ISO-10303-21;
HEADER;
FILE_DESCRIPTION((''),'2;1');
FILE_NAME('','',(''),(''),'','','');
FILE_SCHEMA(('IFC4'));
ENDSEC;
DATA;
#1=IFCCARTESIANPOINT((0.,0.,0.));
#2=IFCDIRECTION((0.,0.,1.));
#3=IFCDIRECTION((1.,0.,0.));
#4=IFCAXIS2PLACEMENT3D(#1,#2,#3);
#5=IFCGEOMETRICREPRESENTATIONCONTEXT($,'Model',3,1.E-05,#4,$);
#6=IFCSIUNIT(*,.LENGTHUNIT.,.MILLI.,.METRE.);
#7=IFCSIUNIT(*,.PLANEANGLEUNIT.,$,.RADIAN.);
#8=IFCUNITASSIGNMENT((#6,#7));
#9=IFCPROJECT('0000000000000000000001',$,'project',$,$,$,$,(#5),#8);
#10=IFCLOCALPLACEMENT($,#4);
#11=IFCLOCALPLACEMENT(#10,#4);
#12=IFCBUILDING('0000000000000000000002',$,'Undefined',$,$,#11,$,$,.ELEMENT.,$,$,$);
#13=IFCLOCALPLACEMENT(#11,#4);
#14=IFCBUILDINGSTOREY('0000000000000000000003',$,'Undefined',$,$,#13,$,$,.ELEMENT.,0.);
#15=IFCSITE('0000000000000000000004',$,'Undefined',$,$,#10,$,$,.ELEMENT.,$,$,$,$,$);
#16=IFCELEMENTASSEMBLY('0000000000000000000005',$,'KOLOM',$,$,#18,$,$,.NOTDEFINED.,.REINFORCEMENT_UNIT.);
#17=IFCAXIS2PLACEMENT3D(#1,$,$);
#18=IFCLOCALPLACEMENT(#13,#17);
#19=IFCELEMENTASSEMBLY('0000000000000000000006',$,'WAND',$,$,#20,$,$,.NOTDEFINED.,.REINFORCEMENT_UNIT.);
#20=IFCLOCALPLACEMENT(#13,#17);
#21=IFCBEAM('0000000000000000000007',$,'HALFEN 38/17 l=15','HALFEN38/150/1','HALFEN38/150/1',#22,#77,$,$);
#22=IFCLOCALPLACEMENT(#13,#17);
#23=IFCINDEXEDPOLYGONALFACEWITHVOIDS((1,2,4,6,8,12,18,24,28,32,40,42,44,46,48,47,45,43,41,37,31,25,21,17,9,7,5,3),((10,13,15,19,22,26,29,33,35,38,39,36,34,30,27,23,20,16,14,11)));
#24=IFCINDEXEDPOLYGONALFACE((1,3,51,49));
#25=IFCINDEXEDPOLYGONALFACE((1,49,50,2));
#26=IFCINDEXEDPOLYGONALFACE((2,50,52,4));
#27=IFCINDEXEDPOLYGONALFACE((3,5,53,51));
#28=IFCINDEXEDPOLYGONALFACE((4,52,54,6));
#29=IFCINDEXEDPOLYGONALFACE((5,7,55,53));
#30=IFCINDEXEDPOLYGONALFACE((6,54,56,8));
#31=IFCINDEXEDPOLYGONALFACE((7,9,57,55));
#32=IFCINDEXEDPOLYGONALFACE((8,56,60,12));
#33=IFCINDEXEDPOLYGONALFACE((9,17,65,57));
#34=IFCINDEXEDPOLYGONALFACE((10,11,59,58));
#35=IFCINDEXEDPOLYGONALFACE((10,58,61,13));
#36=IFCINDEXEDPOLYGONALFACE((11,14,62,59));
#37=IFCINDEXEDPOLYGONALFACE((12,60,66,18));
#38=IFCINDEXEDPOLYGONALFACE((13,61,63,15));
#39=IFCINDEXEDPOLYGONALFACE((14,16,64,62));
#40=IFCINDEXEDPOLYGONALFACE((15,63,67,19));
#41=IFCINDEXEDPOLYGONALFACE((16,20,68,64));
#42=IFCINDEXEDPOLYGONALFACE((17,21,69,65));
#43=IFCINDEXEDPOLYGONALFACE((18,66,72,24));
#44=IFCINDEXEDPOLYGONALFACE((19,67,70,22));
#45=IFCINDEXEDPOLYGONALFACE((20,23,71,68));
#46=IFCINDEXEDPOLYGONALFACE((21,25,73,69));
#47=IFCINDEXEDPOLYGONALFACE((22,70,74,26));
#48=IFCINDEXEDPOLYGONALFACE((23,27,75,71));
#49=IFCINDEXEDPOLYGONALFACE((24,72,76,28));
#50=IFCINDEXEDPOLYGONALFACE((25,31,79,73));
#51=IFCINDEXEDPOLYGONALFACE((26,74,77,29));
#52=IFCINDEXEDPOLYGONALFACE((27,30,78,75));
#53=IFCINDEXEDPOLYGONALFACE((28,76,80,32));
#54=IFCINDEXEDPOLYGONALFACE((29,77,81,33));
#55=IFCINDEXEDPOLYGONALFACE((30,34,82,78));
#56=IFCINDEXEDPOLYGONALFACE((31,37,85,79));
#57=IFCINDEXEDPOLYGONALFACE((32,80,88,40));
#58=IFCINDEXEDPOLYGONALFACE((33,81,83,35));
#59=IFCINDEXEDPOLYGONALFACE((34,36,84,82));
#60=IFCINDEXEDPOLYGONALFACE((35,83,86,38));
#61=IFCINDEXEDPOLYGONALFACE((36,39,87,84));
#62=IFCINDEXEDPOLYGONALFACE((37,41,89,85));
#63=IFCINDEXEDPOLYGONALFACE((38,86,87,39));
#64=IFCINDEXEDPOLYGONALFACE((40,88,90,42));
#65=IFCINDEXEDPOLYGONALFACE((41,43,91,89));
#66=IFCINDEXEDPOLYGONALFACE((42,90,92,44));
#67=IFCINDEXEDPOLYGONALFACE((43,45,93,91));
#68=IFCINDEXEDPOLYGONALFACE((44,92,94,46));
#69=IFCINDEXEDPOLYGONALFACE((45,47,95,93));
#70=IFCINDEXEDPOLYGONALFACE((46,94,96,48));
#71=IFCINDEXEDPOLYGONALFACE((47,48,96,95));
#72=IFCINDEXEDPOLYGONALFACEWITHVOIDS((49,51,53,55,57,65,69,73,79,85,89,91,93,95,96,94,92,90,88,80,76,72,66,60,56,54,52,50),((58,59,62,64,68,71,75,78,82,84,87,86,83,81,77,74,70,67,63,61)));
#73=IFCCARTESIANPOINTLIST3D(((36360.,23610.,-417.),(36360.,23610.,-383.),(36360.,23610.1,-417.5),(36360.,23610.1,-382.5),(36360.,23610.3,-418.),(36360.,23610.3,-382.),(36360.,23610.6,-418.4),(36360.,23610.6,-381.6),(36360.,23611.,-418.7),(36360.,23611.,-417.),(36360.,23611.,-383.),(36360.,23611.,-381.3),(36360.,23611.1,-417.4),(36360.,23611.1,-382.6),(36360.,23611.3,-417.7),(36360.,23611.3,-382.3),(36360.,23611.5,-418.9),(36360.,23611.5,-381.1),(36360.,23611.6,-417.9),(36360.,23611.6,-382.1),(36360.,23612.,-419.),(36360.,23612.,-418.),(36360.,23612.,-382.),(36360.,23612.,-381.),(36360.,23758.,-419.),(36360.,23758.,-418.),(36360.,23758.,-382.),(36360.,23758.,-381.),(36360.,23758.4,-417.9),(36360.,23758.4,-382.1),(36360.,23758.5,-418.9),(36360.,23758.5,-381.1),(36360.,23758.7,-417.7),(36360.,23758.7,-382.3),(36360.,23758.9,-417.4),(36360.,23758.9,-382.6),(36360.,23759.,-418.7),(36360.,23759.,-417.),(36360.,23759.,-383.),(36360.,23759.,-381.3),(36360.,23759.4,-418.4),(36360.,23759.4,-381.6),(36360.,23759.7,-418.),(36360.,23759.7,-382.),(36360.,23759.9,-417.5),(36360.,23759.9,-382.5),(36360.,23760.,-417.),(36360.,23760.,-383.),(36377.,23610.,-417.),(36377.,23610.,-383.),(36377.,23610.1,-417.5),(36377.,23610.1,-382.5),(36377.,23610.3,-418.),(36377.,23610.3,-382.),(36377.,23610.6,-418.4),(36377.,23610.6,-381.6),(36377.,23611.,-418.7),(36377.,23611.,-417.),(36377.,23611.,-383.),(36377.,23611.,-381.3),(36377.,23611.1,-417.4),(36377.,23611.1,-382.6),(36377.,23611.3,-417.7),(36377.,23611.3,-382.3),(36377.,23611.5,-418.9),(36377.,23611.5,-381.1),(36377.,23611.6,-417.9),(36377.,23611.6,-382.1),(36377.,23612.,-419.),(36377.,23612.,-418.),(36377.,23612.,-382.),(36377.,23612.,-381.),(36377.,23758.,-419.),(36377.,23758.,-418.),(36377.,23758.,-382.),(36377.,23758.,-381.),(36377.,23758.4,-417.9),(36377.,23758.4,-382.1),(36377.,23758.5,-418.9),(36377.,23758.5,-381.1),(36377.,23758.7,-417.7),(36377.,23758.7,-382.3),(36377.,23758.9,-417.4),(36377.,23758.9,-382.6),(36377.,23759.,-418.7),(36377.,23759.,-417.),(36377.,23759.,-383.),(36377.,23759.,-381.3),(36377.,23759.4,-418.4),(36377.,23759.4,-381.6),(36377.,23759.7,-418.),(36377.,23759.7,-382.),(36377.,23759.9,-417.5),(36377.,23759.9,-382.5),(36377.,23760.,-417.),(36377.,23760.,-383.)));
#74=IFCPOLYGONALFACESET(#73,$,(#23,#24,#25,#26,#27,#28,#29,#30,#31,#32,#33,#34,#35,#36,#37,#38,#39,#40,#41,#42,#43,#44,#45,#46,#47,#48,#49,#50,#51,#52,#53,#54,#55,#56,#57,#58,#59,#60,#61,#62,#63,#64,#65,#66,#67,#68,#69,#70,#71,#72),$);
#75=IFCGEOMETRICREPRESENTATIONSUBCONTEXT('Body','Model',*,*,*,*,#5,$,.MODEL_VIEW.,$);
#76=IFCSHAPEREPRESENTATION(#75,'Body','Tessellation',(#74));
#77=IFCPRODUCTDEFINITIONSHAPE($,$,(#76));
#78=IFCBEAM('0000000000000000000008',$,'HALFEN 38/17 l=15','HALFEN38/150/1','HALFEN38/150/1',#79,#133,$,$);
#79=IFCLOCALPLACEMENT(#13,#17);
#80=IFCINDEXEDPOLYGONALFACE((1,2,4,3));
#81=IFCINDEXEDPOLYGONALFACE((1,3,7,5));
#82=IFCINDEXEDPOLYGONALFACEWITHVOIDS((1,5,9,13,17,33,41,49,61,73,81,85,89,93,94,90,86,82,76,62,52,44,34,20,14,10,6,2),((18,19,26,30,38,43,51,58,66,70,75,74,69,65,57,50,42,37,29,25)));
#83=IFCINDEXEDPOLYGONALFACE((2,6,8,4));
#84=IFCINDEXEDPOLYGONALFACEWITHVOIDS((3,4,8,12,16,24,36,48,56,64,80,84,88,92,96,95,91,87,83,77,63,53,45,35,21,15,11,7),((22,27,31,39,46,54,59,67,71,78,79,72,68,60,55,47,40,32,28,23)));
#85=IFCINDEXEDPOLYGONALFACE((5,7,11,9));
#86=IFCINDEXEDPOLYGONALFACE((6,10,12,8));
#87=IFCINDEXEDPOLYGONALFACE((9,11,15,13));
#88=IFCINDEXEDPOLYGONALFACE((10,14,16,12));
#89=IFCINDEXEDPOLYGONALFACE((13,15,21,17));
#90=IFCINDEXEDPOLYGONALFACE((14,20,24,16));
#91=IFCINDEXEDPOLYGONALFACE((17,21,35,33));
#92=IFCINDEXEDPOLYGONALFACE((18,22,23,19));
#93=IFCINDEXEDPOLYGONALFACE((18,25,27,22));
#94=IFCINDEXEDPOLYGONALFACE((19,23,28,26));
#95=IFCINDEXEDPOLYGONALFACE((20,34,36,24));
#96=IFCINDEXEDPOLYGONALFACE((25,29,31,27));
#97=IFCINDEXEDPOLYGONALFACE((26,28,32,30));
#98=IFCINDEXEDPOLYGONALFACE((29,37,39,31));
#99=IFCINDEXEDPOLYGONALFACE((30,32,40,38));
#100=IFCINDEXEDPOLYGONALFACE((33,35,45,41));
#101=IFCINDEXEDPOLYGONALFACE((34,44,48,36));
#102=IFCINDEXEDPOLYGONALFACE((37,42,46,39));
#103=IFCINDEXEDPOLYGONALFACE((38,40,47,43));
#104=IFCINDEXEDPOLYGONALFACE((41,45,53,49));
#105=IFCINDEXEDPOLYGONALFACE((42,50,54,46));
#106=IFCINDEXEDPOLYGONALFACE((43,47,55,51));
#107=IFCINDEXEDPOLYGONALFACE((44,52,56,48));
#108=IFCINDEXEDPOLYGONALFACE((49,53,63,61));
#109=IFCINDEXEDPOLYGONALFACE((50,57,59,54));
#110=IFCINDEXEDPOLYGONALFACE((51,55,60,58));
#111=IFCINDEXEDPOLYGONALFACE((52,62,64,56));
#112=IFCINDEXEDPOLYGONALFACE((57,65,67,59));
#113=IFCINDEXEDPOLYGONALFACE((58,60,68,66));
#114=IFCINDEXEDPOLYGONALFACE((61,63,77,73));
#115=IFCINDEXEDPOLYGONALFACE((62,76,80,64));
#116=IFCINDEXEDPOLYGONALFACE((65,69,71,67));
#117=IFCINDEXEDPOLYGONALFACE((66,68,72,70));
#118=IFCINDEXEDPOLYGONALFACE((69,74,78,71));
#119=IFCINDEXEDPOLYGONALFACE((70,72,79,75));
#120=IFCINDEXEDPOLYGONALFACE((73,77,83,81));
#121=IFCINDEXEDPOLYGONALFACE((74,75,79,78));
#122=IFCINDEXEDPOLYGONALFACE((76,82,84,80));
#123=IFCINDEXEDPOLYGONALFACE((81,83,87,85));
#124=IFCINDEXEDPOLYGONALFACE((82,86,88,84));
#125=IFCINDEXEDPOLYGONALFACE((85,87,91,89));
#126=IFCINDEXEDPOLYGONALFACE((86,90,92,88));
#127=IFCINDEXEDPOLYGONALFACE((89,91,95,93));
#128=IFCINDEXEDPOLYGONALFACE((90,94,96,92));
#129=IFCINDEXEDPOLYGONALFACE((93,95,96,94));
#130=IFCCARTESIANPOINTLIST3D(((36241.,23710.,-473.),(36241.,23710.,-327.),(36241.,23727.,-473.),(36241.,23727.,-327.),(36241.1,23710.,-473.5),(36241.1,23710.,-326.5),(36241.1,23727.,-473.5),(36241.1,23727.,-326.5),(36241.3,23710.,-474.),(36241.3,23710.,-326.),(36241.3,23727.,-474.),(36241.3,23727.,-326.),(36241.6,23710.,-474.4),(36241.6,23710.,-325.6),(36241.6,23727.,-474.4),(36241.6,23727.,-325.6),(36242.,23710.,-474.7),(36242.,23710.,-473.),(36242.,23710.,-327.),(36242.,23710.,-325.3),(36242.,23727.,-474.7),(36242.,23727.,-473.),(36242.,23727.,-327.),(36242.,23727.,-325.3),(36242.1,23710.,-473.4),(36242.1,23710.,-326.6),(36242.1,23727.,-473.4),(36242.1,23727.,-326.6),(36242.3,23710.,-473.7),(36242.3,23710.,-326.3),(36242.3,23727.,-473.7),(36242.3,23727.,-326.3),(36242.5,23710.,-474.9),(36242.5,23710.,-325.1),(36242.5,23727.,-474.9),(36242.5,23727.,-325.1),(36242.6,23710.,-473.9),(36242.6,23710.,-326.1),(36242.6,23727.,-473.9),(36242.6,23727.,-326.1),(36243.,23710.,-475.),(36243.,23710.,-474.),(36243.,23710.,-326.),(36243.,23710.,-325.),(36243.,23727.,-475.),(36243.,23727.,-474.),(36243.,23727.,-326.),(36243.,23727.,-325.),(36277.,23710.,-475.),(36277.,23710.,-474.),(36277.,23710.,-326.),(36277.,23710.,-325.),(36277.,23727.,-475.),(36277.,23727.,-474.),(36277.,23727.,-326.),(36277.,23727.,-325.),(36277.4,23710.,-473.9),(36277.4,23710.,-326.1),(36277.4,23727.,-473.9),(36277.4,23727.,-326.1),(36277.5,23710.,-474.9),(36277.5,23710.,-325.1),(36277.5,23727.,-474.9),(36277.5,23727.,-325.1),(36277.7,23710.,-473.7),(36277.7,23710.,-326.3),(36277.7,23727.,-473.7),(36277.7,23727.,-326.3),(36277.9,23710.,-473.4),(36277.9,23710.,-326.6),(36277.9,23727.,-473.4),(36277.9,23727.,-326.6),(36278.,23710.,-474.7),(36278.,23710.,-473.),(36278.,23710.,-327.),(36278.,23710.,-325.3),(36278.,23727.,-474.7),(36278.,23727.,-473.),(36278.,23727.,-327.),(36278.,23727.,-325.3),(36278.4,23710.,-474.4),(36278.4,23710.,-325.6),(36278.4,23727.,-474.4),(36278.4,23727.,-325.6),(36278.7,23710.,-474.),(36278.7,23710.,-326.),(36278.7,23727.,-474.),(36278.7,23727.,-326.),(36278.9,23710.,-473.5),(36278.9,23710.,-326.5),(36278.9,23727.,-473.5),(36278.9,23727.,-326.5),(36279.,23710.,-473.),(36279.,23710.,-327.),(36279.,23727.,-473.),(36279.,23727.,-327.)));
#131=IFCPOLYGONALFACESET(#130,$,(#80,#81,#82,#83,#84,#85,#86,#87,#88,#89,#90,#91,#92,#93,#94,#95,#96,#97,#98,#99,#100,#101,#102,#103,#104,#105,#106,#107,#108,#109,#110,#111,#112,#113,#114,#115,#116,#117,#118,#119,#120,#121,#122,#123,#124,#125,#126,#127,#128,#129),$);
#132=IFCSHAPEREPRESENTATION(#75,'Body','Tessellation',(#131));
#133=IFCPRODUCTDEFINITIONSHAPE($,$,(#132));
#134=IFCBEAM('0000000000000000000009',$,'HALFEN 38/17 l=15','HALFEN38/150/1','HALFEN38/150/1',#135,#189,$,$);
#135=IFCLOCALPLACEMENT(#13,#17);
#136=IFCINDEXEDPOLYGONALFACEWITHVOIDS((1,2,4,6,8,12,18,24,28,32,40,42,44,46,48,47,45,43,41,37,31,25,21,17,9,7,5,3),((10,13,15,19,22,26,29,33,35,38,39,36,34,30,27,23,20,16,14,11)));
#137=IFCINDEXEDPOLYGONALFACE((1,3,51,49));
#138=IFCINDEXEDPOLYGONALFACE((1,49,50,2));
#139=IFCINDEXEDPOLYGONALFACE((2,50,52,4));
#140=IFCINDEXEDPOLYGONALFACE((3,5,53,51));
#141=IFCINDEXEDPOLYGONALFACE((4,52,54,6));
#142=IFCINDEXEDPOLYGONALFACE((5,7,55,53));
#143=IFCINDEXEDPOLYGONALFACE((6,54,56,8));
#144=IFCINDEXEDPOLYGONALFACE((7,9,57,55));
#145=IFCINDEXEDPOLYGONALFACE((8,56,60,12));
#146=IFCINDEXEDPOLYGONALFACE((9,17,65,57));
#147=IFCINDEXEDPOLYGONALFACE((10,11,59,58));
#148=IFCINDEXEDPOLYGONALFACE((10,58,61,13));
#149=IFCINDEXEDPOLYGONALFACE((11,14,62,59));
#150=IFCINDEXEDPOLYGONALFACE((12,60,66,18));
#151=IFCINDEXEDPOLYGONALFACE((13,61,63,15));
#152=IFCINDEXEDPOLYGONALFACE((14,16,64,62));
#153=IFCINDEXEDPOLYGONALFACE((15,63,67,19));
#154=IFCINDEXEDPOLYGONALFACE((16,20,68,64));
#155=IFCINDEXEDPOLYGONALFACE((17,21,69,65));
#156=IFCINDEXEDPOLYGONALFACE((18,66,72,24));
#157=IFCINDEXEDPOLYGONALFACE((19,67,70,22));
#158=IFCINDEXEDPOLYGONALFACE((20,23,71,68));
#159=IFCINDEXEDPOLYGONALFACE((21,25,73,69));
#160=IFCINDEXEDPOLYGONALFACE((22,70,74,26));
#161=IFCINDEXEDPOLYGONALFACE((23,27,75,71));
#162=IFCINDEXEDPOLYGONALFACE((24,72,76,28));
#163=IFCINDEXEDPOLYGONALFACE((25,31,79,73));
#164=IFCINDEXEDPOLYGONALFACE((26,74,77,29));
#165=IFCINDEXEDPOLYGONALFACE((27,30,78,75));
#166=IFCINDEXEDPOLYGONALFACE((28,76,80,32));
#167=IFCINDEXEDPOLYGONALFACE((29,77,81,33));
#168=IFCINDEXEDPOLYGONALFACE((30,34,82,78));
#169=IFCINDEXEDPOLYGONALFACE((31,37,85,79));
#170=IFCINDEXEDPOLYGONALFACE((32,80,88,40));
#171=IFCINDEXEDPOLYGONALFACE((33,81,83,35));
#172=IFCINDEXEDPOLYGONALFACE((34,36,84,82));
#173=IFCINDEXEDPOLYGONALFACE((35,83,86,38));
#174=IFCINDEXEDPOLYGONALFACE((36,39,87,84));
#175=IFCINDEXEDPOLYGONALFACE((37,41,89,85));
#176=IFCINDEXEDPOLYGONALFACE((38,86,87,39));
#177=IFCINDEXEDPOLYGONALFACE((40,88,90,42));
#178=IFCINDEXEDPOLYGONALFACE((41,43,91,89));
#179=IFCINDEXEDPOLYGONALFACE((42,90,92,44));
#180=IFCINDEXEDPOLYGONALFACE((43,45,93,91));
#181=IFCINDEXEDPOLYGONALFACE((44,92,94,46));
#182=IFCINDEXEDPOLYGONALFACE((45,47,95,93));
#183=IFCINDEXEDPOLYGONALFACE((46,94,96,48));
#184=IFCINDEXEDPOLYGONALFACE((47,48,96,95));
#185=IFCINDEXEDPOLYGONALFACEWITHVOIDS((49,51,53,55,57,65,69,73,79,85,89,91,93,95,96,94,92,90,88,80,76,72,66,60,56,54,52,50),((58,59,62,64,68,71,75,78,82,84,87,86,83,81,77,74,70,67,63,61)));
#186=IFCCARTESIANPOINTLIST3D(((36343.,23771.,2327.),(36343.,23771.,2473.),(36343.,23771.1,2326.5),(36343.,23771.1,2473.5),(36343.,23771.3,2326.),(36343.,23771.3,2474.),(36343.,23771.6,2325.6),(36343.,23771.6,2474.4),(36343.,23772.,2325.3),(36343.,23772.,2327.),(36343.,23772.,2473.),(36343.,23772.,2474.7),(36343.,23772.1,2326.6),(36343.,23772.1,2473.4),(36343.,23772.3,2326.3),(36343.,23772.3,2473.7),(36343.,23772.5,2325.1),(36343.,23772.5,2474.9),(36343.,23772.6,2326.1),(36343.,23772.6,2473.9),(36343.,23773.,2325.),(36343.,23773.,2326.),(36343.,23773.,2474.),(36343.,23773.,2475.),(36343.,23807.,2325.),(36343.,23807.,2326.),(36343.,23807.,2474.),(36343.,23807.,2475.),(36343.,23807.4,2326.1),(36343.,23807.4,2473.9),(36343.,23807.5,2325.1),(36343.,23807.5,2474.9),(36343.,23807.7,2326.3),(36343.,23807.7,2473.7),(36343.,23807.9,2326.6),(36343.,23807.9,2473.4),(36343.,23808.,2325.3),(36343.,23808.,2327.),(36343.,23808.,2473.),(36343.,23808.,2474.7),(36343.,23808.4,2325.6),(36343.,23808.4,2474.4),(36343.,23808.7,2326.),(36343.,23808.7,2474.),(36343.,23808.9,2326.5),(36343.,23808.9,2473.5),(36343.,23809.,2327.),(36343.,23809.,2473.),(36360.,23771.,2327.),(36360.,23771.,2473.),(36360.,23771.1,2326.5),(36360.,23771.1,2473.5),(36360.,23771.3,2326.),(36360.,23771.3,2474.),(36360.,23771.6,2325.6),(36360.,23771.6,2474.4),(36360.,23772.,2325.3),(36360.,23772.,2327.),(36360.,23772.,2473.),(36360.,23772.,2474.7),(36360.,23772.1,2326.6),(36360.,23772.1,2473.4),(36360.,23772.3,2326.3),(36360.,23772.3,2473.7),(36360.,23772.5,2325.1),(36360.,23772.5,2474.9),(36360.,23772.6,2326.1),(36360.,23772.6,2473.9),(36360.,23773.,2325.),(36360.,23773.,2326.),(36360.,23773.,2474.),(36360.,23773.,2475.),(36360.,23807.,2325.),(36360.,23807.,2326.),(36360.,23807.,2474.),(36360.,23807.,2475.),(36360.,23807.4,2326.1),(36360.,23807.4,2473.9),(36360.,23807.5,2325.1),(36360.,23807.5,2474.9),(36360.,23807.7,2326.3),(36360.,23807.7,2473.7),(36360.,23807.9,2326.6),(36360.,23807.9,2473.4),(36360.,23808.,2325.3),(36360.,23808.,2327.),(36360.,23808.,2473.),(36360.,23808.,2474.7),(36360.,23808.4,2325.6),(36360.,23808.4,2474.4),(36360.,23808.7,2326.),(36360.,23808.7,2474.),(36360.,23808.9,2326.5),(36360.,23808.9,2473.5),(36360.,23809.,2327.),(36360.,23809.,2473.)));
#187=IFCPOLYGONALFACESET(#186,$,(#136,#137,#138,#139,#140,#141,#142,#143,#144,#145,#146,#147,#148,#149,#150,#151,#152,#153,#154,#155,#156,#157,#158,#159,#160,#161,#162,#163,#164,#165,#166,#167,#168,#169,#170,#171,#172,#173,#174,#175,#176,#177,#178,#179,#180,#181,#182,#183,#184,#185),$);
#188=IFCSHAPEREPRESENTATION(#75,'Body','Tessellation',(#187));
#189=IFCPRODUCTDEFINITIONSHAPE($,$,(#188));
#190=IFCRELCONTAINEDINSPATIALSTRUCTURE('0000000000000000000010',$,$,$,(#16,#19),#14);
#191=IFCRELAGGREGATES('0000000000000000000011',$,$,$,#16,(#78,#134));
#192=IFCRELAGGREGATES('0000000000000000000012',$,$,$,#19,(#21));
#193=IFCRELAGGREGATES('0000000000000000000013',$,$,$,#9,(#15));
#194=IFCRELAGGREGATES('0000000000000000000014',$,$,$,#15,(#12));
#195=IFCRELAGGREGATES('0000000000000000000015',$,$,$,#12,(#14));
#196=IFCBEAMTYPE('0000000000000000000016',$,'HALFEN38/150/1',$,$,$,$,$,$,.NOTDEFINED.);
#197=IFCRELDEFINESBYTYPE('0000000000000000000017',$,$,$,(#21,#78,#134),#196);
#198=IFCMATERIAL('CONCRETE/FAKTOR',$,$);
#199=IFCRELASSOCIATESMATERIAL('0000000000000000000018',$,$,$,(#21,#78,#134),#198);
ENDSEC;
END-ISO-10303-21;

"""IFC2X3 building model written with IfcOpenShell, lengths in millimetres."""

from ifc_helpers import new_model, si_unit, frame, frame_2d, origin_with_axes, place, context, subcontext, project, spatial, hollow_rectangle, extrude, material, type_object, element, aggregate, save


model = new_model("IFC2X3")

# Units and contexts
model_context = context("Model", 3, precision=1e-05, world=origin_with_axes())
body_context = subcontext(model_context, "Body", "Model", "MODEL_VIEW")
ifc_project = project(units=[si_unit("LENGTHUNIT", "METRE", prefix="MILLI"), si_unit("PLANEANGLEUNIT", "RADIAN")], contexts=[model_context])

# Site, building, storey
site_placement = place(None, origin_with_axes())
site = spatial("IfcSite", under=ifc_project, at=site_placement, Name="Undefined", CompositionType="ELEMENT")
building_placement = place(site_placement, origin_with_axes())
building = spatial("IfcBuilding", under=site, at=building_placement, Name="Undefined", CompositionType="ELEMENT")
storey_placement = place(building_placement, origin_with_axes())
storey = spatial("IfcBuildingStorey", under=building, at=storey_placement, Name="Undefined", CompositionType="ELEMENT", Elevation=0.0)

# Element assemblies, beam
ifc_material_1 = material(Name="CONCRETE/FAKTOR")
assembly_1_placement = place(storey_placement, origin_with_axes())
assembly_1 = element("IfcElementAssembly", 1, at=assembly_1_placement, inside=storey, Name="KOLOM", AssemblyPlace="NOTDEFINED", PredefinedType="REINFORCEMENT_UNIT")
beam_type_1 = type_object("IfcBeamType", Name="HALFEN38/150/1", PredefinedType="NOTDEFINED")
assembly_2_placement = place(storey_placement, origin_with_axes())
assembly_2 = element("IfcElementAssembly", 2, at=assembly_2_placement, inside=storey, Name="WAND", AssemblyPlace="NOTDEFINED", PredefinedType="REINFORCEMENT_UNIT")
beam_1_placement = place(assembly_2_placement, frame((36360.0, 23685.0, -400.0), z_axis=(0.0, 0.0, 1.0), x_axis=(1.0, 0.0, 0.0)))
beam_1 = element("IfcBeam", 3, at=beam_1_placement, type_object=beam_type_1, material=ifc_material_1, Name="HALFEN 38/17 l=15", Description="HALFEN38/150/1", ObjectType="HALFEN38/150/1", context=body_context, shape_type="SweptSolid", body=[
    extrude(hollow_rectangle(XDim=150.0, YDim=38.0, WallThickness=1.0, InnerFilletRadius=1.0, OuterFilletRadius=2.0, at=frame_2d((0.0, 0.0), x_axis=(1.0, 0.0))), frame((17.0, 0.0, 0.0), z_axis=(-1.0, 0.0, 0.0), x_axis=(0.0, -1.0, 0.0)), (0.0, 0.0, 1.0), 17.0),
])

# Beams
beam_2_placement = place(assembly_1_placement, frame((36260.0, 23710.0, -400.0), z_axis=(-1.0, 0.0, 0.0), x_axis=(0.0, 1.0, 0.0)))
beam_2 = element("IfcBeam", 4, at=beam_2_placement, type_object=beam_type_1, material=ifc_material_1, Name="HALFEN 38/17 l=15", Description="HALFEN38/150/1", ObjectType="HALFEN38/150/1", context=body_context, shape_type="SweptSolid", body=[
    extrude(hollow_rectangle(XDim=150.0, YDim=38.0, WallThickness=1.0, InnerFilletRadius=1.0, OuterFilletRadius=2.0, at=frame_2d((0.0, 0.0), x_axis=(1.0, 0.0))), frame((17.0, 0.0, 0.0), z_axis=(-1.0, 0.0, 0.0), x_axis=(0.0, -1.0, 0.0)), (0.0, 0.0, 1.0), 17.0),
])
beam_3_placement = place(assembly_1_placement, frame((36360.0, 23790.0, 2400.0), z_axis=(0.0, -1.0, 0.0), x_axis=(-1.0, 0.0, 0.0)))
beam_3 = element("IfcBeam", 5, at=beam_3_placement, type_object=beam_type_1, material=ifc_material_1, Name="HALFEN 38/17 l=15", Description="HALFEN38/150/1", ObjectType="HALFEN38/150/1", context=body_context, shape_type="SweptSolid", body=[
    extrude(hollow_rectangle(XDim=150.0, YDim=38.0, WallThickness=1.0, InnerFilletRadius=1.0, OuterFilletRadius=2.0, at=frame_2d((0.0, 0.0), x_axis=(1.0, 0.0))), frame((17.0, 0.0, 0.0), z_axis=(-1.0, 0.0, 0.0), x_axis=(0.0, -1.0, 0.0)), (0.0, 0.0, 1.0), 17.0),
])
aggregate(assembly_1, [beam_2, beam_3])

aggregate(assembly_2, [beam_1])

save(model, "model.ifc")
